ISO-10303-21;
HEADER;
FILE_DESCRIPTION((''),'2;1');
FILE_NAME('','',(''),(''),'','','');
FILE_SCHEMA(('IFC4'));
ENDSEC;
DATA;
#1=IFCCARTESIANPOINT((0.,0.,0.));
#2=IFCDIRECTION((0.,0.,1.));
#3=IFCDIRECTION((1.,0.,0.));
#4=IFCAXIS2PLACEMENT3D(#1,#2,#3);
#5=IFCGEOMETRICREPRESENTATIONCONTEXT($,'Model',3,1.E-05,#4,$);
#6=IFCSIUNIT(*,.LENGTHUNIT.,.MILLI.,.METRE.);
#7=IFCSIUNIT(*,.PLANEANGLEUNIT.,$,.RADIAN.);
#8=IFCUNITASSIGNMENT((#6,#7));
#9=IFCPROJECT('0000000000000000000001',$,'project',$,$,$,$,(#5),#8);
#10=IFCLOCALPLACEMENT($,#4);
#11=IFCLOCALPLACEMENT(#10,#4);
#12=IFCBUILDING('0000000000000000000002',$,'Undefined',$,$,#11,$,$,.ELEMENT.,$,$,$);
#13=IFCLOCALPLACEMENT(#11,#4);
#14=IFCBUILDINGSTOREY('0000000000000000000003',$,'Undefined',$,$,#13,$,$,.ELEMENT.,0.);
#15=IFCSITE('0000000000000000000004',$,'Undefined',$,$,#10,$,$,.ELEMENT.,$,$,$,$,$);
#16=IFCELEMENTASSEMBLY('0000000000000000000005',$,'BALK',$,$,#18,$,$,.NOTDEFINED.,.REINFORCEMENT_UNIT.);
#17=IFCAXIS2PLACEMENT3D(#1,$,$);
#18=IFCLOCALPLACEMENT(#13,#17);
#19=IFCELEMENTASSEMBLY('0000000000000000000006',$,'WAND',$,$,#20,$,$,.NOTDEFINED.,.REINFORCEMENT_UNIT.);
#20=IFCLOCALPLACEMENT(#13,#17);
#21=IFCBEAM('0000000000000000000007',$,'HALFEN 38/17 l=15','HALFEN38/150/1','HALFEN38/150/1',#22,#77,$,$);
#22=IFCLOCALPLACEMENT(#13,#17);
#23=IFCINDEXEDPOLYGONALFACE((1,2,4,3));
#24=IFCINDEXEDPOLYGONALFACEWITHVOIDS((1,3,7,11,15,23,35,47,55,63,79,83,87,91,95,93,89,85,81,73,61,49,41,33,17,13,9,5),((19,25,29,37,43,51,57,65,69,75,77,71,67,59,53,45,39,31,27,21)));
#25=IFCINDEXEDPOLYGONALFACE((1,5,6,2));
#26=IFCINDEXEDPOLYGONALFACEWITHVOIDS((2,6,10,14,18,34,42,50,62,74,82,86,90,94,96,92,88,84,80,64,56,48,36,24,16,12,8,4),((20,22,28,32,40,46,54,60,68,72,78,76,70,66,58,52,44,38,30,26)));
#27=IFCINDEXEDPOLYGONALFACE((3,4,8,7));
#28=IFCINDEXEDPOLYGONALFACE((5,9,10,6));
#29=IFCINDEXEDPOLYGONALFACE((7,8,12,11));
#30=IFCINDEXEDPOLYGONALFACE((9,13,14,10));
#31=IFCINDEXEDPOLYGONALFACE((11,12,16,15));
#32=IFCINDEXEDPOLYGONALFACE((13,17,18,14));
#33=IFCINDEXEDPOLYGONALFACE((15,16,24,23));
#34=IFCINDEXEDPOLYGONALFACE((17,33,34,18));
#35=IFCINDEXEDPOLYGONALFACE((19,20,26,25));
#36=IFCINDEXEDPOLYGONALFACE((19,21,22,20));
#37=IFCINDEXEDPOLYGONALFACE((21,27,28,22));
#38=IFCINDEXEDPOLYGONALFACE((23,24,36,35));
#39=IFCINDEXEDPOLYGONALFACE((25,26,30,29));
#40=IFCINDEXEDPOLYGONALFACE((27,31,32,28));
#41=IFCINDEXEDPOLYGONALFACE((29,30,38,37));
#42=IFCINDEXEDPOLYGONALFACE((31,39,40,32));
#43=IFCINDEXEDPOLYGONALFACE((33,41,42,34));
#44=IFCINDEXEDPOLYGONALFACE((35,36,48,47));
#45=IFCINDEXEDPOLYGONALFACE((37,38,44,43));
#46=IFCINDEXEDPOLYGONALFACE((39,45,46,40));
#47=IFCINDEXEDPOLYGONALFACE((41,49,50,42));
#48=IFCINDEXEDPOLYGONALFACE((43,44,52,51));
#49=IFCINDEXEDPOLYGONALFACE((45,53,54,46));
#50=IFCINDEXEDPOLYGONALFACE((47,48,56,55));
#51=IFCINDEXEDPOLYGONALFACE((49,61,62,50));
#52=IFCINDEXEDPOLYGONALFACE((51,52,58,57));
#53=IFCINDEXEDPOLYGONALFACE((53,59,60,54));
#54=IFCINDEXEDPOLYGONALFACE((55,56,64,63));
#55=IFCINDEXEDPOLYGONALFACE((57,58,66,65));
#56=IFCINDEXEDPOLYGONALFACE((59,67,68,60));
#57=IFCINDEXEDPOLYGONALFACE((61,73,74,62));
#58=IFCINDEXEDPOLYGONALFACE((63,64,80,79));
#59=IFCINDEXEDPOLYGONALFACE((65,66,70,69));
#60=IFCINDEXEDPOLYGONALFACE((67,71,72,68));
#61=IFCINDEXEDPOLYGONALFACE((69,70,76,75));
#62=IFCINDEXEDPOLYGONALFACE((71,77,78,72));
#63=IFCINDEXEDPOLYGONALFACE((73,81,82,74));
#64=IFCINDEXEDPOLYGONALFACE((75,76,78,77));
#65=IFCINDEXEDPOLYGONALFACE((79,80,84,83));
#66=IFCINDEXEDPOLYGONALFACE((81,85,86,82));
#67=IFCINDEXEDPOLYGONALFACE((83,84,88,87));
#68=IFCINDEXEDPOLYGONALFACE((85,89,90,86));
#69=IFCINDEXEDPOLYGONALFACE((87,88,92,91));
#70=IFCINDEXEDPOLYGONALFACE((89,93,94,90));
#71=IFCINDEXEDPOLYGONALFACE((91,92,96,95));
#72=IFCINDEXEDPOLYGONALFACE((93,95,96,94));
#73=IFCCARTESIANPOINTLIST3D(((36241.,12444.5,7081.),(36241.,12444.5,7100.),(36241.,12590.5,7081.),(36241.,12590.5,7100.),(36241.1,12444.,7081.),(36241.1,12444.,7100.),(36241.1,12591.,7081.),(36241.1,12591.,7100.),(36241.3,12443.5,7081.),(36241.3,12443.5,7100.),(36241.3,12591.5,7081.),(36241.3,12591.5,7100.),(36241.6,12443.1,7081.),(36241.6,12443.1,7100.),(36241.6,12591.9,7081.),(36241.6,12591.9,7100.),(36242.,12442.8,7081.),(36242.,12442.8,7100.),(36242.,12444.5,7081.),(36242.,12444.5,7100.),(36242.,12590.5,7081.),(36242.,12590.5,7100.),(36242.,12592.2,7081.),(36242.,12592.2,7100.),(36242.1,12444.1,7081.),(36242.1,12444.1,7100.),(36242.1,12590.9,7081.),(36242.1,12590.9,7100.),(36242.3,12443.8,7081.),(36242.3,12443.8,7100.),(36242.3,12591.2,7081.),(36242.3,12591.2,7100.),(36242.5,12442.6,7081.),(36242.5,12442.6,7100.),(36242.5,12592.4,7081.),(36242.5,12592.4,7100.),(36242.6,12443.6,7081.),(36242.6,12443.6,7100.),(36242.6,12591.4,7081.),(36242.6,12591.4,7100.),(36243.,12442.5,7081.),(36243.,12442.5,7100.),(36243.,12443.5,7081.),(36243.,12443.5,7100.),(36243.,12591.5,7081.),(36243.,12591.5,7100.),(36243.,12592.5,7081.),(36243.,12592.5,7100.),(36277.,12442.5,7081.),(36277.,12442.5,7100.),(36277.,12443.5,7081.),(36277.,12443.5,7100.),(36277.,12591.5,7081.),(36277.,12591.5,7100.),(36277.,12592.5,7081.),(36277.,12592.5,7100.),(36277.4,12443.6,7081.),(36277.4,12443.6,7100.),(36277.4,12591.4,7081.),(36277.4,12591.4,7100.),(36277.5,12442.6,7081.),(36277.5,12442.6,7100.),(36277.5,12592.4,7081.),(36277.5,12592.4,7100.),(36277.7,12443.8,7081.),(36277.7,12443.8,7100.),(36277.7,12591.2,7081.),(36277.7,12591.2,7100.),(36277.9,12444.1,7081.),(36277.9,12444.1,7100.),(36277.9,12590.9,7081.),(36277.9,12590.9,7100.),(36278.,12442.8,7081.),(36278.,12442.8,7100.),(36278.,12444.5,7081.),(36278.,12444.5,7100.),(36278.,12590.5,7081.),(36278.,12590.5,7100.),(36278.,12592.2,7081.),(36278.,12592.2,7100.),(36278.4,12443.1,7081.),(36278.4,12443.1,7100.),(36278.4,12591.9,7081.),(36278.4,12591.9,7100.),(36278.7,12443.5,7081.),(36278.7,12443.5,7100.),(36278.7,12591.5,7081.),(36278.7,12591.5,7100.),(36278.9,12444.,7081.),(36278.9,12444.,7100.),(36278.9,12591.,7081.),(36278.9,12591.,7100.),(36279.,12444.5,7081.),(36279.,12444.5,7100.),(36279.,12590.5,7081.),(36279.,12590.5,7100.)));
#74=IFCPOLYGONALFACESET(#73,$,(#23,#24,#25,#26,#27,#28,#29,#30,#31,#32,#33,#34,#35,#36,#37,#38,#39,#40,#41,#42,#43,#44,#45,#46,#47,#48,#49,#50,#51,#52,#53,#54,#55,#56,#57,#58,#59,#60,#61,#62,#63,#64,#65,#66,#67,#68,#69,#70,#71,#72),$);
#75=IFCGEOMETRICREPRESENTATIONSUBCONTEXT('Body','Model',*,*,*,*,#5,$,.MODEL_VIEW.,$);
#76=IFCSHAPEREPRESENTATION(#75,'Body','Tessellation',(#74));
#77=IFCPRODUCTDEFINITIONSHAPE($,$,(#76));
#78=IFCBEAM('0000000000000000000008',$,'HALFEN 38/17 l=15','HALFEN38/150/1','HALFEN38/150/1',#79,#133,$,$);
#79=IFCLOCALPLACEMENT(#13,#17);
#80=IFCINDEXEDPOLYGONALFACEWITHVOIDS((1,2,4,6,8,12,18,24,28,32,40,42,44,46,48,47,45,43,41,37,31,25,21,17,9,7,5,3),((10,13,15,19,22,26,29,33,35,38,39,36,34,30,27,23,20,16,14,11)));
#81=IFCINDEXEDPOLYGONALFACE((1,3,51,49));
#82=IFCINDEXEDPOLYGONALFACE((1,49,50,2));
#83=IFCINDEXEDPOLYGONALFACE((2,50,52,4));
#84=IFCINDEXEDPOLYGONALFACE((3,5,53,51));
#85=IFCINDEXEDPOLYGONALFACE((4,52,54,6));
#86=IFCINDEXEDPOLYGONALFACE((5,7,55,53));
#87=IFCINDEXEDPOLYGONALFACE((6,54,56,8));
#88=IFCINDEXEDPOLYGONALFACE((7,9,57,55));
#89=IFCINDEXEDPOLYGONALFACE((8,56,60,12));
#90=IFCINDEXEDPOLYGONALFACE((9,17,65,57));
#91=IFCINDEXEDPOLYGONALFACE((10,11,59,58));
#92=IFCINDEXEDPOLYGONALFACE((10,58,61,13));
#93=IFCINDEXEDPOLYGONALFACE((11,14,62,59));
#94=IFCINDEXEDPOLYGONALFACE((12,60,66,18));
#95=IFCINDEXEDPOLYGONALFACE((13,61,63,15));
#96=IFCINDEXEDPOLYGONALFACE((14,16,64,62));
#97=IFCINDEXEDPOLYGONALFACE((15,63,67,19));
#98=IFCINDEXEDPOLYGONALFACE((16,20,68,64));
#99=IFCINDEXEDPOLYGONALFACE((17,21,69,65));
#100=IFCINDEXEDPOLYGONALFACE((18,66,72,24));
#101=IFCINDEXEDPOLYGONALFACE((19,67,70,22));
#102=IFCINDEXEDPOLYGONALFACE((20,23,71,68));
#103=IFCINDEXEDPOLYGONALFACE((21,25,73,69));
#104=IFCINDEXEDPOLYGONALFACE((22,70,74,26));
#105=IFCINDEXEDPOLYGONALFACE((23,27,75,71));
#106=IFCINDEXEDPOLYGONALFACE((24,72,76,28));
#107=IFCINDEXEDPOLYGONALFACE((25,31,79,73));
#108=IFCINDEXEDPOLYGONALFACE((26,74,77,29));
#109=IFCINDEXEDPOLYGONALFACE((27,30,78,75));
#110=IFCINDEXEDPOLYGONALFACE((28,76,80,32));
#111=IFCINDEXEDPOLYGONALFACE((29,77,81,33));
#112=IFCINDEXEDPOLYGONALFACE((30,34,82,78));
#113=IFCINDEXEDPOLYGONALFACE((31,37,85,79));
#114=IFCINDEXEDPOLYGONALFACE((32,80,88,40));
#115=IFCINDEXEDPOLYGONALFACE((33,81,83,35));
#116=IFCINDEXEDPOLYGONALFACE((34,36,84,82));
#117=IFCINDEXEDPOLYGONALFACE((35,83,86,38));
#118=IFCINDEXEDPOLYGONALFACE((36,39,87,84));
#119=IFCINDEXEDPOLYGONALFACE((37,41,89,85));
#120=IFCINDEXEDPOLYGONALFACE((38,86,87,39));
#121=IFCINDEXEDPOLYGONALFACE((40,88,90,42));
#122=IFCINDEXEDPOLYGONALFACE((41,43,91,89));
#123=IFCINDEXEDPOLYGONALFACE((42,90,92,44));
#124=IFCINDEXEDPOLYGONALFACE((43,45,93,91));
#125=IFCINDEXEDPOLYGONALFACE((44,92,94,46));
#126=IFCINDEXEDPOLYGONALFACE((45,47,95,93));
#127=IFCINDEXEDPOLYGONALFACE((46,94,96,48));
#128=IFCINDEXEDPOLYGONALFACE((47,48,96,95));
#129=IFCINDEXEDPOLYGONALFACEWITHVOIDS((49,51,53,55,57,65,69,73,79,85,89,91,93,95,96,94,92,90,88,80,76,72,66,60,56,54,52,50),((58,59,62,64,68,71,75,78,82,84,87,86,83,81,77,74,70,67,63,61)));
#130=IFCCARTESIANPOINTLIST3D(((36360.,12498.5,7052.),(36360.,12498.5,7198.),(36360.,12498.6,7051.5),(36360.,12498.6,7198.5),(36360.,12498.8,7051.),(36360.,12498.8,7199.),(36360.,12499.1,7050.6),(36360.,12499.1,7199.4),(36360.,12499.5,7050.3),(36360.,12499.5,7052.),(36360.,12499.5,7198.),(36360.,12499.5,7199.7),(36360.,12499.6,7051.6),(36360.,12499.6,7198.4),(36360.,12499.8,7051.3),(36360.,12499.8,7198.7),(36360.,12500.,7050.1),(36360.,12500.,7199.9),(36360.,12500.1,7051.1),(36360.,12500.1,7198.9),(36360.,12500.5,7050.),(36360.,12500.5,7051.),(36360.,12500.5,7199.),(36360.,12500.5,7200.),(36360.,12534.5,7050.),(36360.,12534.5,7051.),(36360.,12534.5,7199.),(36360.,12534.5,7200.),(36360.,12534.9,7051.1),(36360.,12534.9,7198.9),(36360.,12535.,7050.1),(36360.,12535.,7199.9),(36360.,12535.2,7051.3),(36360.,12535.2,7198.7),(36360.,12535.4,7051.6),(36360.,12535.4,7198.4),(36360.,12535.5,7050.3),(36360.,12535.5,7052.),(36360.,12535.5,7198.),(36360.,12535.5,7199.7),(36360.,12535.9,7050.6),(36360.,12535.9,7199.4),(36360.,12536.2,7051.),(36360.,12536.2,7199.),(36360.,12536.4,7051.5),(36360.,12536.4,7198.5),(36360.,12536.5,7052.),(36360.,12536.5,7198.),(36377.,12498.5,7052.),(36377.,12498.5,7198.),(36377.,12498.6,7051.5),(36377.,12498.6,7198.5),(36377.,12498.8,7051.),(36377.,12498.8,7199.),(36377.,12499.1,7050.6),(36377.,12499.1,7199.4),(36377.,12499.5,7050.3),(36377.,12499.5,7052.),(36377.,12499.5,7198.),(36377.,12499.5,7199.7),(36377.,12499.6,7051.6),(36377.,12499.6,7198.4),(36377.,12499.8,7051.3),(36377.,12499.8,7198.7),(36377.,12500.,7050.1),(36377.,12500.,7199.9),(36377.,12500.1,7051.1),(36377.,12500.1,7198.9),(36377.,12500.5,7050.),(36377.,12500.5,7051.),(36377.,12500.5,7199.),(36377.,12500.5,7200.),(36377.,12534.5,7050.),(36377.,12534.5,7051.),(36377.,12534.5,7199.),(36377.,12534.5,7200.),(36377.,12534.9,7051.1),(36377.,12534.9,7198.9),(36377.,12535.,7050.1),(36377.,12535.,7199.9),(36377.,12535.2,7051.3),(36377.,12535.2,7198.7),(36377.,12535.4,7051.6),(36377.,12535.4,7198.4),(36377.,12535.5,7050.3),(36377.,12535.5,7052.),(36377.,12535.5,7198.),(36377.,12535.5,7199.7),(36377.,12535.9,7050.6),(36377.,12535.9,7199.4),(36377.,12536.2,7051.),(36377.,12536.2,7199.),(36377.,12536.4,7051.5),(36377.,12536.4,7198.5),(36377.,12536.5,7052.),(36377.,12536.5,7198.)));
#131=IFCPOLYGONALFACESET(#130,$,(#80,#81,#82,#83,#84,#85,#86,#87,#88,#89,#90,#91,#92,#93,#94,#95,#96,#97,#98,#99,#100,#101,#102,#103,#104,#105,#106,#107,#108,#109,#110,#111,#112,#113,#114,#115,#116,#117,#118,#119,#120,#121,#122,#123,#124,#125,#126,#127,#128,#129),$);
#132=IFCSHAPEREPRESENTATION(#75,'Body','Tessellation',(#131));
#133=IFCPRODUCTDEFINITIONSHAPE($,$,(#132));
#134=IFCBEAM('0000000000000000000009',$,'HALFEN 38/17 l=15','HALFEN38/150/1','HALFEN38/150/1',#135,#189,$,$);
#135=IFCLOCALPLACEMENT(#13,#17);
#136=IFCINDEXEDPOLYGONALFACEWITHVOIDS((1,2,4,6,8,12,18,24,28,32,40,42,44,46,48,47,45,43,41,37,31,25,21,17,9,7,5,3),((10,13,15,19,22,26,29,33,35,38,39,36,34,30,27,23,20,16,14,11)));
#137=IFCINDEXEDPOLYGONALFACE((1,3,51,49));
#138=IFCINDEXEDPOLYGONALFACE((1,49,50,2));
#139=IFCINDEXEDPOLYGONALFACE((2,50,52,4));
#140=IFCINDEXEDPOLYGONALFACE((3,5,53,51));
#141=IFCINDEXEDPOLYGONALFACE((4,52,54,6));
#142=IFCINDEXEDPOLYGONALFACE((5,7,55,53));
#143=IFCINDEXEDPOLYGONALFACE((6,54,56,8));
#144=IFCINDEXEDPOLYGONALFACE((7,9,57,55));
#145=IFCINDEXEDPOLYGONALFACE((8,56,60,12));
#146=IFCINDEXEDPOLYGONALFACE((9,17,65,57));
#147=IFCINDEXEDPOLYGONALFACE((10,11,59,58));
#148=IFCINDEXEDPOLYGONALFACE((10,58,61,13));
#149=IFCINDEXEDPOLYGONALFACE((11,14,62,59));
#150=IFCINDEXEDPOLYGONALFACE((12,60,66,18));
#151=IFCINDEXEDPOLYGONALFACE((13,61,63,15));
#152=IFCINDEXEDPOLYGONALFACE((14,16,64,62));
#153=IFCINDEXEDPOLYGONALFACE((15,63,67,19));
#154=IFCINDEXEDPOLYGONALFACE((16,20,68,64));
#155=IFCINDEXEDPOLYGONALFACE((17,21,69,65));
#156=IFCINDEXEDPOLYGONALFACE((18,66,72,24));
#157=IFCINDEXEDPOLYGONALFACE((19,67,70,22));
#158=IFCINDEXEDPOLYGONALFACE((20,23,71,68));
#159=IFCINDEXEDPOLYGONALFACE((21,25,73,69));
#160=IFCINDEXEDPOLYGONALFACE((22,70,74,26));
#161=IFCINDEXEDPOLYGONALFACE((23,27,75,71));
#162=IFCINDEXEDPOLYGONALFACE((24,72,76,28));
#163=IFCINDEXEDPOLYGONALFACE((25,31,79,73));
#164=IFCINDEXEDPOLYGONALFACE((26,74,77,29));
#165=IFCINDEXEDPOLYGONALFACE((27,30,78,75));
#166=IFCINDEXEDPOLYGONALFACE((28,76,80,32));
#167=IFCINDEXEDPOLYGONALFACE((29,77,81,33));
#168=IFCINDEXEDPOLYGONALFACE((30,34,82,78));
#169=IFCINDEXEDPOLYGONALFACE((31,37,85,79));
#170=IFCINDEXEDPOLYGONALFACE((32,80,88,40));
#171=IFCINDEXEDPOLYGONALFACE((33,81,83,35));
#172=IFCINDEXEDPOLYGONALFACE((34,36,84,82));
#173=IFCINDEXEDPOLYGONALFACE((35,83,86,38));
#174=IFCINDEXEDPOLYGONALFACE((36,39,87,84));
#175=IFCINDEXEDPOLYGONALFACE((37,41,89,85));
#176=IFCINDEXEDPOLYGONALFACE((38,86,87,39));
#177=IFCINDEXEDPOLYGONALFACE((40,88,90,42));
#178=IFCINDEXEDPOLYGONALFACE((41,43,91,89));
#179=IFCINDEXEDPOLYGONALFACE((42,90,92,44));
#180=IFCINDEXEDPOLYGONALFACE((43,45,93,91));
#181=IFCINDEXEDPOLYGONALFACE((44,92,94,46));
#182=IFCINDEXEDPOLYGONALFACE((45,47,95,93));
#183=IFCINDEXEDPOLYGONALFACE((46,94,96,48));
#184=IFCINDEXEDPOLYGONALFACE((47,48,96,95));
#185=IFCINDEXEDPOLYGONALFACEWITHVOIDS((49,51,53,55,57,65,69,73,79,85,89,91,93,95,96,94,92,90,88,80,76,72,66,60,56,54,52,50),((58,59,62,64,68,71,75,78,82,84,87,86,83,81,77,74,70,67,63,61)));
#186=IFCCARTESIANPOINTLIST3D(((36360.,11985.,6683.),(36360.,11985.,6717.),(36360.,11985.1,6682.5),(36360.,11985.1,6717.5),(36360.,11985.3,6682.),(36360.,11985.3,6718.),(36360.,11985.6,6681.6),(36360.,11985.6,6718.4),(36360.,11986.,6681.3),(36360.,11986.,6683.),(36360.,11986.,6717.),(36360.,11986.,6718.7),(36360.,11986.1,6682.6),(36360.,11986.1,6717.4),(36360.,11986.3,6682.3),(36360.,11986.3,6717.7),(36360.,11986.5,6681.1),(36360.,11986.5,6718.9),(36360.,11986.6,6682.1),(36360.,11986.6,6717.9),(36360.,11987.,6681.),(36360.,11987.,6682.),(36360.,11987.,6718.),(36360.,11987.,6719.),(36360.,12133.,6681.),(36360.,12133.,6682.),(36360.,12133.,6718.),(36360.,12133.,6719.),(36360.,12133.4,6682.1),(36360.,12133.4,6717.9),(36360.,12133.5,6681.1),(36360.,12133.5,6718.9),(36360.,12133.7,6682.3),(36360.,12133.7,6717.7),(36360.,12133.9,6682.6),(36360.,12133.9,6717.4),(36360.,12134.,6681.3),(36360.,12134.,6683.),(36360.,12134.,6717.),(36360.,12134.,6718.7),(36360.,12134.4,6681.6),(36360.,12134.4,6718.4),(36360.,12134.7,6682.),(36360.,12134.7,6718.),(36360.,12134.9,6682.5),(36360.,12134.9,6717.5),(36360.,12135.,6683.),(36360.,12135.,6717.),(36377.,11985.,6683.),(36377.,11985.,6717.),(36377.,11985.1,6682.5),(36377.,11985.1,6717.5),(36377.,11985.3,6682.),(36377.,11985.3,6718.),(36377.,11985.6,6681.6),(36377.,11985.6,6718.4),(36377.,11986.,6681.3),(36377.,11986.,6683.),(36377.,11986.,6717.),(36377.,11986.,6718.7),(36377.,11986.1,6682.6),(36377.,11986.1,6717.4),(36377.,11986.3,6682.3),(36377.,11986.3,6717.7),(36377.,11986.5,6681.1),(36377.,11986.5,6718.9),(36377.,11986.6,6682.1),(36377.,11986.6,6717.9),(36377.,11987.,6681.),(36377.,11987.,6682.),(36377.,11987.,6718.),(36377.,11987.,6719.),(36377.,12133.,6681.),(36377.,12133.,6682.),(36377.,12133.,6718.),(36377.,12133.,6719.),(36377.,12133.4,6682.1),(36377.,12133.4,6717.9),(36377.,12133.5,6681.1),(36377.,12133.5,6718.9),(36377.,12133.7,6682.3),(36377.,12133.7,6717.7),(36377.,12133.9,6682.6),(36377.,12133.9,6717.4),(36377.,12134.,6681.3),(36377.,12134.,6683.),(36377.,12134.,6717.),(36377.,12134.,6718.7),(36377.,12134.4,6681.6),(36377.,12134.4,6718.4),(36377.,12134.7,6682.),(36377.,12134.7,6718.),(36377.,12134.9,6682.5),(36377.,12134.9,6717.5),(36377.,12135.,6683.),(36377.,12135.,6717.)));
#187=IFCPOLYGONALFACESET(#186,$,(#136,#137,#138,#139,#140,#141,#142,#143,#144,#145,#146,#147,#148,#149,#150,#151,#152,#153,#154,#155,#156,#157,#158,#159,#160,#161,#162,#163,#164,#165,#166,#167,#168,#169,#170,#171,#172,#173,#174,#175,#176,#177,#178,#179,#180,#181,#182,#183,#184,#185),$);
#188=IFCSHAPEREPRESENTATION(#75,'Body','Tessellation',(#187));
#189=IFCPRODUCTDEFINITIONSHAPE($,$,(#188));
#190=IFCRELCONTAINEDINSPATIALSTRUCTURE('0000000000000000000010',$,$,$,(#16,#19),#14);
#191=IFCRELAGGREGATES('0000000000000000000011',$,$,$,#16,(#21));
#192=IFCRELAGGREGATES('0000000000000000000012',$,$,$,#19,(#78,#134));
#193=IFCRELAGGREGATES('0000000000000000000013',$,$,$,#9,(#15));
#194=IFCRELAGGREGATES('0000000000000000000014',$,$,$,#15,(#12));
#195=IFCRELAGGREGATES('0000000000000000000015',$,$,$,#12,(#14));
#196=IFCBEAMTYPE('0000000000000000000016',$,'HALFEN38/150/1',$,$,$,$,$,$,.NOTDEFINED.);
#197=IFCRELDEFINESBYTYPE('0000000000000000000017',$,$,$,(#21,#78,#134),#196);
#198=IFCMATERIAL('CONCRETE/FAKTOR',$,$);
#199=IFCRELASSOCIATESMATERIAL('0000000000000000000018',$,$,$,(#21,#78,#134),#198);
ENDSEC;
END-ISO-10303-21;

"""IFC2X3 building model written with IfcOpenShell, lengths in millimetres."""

from ifc_helpers import new_model, si_unit, frame, frame_2d, origin_with_axes, place, context, subcontext, project, spatial, hollow_rectangle, extrude, material, type_object, element, aggregate, save


model = new_model("IFC2X3")

# Units and contexts
model_context = context("Model", 3, precision=1e-05, world=origin_with_axes())
body_context = subcontext(model_context, "Body", "Model", "MODEL_VIEW")
ifc_project = project(units=[si_unit("LENGTHUNIT", "METRE", prefix="MILLI"), si_unit("PLANEANGLEUNIT", "RADIAN")], contexts=[model_context])

# Site, building, storey
site_placement = place(None, origin_with_axes())
site = spatial("IfcSite", under=ifc_project, at=site_placement, Name="Undefined", CompositionType="ELEMENT")
building_placement = place(site_placement, origin_with_axes())
building = spatial("IfcBuilding", under=site, at=building_placement, Name="Undefined", CompositionType="ELEMENT")
storey_placement = place(building_placement, origin_with_axes())
storey = spatial("IfcBuildingStorey", under=building, at=storey_placement, Name="Undefined", CompositionType="ELEMENT", Elevation=0.0)

# Shared definitions
ifc_material_1 = material(Name="CONCRETE/FAKTOR")

# Element assembly
assembly_1_placement = place(storey_placement, origin_with_axes())
assembly_1 = element("IfcElementAssembly", 1, at=assembly_1_placement, inside=storey, Name="BALK", AssemblyPlace="NOTDEFINED", PredefinedType="REINFORCEMENT_UNIT")

# Element assembly
assembly_2_placement = place(storey_placement, origin_with_axes())
assembly_2 = element("IfcElementAssembly", 2, at=assembly_2_placement, inside=storey, Name="WAND", AssemblyPlace="NOTDEFINED", PredefinedType="REINFORCEMENT_UNIT")

# Beams
beam_type_1 = type_object("IfcBeamType", Name="HALFEN38/150/1", PredefinedType="NOTDEFINED")
beam_1_placement = place(assembly_1_placement, frame((36260.0, 12517.5, 7100.0), z_axis=(1.0, 0.0, 0.0), x_axis=(0.0, 0.0, -1.0)))
beam_1 = element("IfcBeam", 3, at=beam_1_placement, type_object=beam_type_1, material=ifc_material_1, Name="HALFEN 38/17 l=15", Description="HALFEN38/150/1", ObjectType="HALFEN38/150/1", context=body_context, shape_type="SweptSolid", body=[
    extrude(hollow_rectangle(XDim=150.0, YDim=38.0, WallThickness=1.0, InnerFilletRadius=1.0, OuterFilletRadius=2.0, at=frame_2d((0.0, 0.0), x_axis=(1.0, 0.0))), frame((19.0, 0.0, 0.0), z_axis=(-1.0, 0.0, 0.0), x_axis=(0.0, -1.0, 0.0)), (0.0, 0.0, 1.0), 19.0),
])
beam_2_placement = place(assembly_2_placement, frame((36360.0, 12517.5, 7125.0), z_axis=(0.0, -1.0, 0.0), x_axis=(1.0, 0.0, 0.0)))
beam_2 = element("IfcBeam", 4, at=beam_2_placement, type_object=beam_type_1, material=ifc_material_1, Name="HALFEN 38/17 l=15", Description="HALFEN38/150/1", ObjectType="HALFEN38/150/1", context=body_context, shape_type="SweptSolid", body=[
    extrude(hollow_rectangle(XDim=150.0, YDim=38.0, WallThickness=1.0, InnerFilletRadius=1.0, OuterFilletRadius=2.0, at=frame_2d((0.0, 0.0), x_axis=(1.0, 0.0))), frame((17.0, 0.0, 0.0), z_axis=(-1.0, 0.0, 0.0), x_axis=(0.0, -1.0, 0.0)), (0.0, 0.0, 1.0), 17.0),
])
beam_3_placement = place(assembly_2_placement, frame((36360.0, 12060.0, 6700.0), z_axis=(0.0, 0.0, -1.0), x_axis=(1.0, 0.0, 0.0)))
beam_3 = element("IfcBeam", 5, at=beam_3_placement, type_object=beam_type_1, material=ifc_material_1, Name="HALFEN 38/17 l=15", Description="HALFEN38/150/1", ObjectType="HALFEN38/150/1", context=body_context, shape_type="SweptSolid", body=[
    extrude(hollow_rectangle(XDim=150.0, YDim=38.0, WallThickness=1.0, InnerFilletRadius=1.0, OuterFilletRadius=2.0, at=frame_2d((0.0, 0.0), x_axis=(1.0, 0.0))), frame((17.0, 0.0, 0.0), z_axis=(-1.0, 0.0, 0.0), x_axis=(0.0, -1.0, 0.0)), (0.0, 0.0, 1.0), 17.0),
])

aggregate(assembly_1, [beam_1])
aggregate(assembly_2, [beam_2, beam_3])

save(model, "model.ifc")
